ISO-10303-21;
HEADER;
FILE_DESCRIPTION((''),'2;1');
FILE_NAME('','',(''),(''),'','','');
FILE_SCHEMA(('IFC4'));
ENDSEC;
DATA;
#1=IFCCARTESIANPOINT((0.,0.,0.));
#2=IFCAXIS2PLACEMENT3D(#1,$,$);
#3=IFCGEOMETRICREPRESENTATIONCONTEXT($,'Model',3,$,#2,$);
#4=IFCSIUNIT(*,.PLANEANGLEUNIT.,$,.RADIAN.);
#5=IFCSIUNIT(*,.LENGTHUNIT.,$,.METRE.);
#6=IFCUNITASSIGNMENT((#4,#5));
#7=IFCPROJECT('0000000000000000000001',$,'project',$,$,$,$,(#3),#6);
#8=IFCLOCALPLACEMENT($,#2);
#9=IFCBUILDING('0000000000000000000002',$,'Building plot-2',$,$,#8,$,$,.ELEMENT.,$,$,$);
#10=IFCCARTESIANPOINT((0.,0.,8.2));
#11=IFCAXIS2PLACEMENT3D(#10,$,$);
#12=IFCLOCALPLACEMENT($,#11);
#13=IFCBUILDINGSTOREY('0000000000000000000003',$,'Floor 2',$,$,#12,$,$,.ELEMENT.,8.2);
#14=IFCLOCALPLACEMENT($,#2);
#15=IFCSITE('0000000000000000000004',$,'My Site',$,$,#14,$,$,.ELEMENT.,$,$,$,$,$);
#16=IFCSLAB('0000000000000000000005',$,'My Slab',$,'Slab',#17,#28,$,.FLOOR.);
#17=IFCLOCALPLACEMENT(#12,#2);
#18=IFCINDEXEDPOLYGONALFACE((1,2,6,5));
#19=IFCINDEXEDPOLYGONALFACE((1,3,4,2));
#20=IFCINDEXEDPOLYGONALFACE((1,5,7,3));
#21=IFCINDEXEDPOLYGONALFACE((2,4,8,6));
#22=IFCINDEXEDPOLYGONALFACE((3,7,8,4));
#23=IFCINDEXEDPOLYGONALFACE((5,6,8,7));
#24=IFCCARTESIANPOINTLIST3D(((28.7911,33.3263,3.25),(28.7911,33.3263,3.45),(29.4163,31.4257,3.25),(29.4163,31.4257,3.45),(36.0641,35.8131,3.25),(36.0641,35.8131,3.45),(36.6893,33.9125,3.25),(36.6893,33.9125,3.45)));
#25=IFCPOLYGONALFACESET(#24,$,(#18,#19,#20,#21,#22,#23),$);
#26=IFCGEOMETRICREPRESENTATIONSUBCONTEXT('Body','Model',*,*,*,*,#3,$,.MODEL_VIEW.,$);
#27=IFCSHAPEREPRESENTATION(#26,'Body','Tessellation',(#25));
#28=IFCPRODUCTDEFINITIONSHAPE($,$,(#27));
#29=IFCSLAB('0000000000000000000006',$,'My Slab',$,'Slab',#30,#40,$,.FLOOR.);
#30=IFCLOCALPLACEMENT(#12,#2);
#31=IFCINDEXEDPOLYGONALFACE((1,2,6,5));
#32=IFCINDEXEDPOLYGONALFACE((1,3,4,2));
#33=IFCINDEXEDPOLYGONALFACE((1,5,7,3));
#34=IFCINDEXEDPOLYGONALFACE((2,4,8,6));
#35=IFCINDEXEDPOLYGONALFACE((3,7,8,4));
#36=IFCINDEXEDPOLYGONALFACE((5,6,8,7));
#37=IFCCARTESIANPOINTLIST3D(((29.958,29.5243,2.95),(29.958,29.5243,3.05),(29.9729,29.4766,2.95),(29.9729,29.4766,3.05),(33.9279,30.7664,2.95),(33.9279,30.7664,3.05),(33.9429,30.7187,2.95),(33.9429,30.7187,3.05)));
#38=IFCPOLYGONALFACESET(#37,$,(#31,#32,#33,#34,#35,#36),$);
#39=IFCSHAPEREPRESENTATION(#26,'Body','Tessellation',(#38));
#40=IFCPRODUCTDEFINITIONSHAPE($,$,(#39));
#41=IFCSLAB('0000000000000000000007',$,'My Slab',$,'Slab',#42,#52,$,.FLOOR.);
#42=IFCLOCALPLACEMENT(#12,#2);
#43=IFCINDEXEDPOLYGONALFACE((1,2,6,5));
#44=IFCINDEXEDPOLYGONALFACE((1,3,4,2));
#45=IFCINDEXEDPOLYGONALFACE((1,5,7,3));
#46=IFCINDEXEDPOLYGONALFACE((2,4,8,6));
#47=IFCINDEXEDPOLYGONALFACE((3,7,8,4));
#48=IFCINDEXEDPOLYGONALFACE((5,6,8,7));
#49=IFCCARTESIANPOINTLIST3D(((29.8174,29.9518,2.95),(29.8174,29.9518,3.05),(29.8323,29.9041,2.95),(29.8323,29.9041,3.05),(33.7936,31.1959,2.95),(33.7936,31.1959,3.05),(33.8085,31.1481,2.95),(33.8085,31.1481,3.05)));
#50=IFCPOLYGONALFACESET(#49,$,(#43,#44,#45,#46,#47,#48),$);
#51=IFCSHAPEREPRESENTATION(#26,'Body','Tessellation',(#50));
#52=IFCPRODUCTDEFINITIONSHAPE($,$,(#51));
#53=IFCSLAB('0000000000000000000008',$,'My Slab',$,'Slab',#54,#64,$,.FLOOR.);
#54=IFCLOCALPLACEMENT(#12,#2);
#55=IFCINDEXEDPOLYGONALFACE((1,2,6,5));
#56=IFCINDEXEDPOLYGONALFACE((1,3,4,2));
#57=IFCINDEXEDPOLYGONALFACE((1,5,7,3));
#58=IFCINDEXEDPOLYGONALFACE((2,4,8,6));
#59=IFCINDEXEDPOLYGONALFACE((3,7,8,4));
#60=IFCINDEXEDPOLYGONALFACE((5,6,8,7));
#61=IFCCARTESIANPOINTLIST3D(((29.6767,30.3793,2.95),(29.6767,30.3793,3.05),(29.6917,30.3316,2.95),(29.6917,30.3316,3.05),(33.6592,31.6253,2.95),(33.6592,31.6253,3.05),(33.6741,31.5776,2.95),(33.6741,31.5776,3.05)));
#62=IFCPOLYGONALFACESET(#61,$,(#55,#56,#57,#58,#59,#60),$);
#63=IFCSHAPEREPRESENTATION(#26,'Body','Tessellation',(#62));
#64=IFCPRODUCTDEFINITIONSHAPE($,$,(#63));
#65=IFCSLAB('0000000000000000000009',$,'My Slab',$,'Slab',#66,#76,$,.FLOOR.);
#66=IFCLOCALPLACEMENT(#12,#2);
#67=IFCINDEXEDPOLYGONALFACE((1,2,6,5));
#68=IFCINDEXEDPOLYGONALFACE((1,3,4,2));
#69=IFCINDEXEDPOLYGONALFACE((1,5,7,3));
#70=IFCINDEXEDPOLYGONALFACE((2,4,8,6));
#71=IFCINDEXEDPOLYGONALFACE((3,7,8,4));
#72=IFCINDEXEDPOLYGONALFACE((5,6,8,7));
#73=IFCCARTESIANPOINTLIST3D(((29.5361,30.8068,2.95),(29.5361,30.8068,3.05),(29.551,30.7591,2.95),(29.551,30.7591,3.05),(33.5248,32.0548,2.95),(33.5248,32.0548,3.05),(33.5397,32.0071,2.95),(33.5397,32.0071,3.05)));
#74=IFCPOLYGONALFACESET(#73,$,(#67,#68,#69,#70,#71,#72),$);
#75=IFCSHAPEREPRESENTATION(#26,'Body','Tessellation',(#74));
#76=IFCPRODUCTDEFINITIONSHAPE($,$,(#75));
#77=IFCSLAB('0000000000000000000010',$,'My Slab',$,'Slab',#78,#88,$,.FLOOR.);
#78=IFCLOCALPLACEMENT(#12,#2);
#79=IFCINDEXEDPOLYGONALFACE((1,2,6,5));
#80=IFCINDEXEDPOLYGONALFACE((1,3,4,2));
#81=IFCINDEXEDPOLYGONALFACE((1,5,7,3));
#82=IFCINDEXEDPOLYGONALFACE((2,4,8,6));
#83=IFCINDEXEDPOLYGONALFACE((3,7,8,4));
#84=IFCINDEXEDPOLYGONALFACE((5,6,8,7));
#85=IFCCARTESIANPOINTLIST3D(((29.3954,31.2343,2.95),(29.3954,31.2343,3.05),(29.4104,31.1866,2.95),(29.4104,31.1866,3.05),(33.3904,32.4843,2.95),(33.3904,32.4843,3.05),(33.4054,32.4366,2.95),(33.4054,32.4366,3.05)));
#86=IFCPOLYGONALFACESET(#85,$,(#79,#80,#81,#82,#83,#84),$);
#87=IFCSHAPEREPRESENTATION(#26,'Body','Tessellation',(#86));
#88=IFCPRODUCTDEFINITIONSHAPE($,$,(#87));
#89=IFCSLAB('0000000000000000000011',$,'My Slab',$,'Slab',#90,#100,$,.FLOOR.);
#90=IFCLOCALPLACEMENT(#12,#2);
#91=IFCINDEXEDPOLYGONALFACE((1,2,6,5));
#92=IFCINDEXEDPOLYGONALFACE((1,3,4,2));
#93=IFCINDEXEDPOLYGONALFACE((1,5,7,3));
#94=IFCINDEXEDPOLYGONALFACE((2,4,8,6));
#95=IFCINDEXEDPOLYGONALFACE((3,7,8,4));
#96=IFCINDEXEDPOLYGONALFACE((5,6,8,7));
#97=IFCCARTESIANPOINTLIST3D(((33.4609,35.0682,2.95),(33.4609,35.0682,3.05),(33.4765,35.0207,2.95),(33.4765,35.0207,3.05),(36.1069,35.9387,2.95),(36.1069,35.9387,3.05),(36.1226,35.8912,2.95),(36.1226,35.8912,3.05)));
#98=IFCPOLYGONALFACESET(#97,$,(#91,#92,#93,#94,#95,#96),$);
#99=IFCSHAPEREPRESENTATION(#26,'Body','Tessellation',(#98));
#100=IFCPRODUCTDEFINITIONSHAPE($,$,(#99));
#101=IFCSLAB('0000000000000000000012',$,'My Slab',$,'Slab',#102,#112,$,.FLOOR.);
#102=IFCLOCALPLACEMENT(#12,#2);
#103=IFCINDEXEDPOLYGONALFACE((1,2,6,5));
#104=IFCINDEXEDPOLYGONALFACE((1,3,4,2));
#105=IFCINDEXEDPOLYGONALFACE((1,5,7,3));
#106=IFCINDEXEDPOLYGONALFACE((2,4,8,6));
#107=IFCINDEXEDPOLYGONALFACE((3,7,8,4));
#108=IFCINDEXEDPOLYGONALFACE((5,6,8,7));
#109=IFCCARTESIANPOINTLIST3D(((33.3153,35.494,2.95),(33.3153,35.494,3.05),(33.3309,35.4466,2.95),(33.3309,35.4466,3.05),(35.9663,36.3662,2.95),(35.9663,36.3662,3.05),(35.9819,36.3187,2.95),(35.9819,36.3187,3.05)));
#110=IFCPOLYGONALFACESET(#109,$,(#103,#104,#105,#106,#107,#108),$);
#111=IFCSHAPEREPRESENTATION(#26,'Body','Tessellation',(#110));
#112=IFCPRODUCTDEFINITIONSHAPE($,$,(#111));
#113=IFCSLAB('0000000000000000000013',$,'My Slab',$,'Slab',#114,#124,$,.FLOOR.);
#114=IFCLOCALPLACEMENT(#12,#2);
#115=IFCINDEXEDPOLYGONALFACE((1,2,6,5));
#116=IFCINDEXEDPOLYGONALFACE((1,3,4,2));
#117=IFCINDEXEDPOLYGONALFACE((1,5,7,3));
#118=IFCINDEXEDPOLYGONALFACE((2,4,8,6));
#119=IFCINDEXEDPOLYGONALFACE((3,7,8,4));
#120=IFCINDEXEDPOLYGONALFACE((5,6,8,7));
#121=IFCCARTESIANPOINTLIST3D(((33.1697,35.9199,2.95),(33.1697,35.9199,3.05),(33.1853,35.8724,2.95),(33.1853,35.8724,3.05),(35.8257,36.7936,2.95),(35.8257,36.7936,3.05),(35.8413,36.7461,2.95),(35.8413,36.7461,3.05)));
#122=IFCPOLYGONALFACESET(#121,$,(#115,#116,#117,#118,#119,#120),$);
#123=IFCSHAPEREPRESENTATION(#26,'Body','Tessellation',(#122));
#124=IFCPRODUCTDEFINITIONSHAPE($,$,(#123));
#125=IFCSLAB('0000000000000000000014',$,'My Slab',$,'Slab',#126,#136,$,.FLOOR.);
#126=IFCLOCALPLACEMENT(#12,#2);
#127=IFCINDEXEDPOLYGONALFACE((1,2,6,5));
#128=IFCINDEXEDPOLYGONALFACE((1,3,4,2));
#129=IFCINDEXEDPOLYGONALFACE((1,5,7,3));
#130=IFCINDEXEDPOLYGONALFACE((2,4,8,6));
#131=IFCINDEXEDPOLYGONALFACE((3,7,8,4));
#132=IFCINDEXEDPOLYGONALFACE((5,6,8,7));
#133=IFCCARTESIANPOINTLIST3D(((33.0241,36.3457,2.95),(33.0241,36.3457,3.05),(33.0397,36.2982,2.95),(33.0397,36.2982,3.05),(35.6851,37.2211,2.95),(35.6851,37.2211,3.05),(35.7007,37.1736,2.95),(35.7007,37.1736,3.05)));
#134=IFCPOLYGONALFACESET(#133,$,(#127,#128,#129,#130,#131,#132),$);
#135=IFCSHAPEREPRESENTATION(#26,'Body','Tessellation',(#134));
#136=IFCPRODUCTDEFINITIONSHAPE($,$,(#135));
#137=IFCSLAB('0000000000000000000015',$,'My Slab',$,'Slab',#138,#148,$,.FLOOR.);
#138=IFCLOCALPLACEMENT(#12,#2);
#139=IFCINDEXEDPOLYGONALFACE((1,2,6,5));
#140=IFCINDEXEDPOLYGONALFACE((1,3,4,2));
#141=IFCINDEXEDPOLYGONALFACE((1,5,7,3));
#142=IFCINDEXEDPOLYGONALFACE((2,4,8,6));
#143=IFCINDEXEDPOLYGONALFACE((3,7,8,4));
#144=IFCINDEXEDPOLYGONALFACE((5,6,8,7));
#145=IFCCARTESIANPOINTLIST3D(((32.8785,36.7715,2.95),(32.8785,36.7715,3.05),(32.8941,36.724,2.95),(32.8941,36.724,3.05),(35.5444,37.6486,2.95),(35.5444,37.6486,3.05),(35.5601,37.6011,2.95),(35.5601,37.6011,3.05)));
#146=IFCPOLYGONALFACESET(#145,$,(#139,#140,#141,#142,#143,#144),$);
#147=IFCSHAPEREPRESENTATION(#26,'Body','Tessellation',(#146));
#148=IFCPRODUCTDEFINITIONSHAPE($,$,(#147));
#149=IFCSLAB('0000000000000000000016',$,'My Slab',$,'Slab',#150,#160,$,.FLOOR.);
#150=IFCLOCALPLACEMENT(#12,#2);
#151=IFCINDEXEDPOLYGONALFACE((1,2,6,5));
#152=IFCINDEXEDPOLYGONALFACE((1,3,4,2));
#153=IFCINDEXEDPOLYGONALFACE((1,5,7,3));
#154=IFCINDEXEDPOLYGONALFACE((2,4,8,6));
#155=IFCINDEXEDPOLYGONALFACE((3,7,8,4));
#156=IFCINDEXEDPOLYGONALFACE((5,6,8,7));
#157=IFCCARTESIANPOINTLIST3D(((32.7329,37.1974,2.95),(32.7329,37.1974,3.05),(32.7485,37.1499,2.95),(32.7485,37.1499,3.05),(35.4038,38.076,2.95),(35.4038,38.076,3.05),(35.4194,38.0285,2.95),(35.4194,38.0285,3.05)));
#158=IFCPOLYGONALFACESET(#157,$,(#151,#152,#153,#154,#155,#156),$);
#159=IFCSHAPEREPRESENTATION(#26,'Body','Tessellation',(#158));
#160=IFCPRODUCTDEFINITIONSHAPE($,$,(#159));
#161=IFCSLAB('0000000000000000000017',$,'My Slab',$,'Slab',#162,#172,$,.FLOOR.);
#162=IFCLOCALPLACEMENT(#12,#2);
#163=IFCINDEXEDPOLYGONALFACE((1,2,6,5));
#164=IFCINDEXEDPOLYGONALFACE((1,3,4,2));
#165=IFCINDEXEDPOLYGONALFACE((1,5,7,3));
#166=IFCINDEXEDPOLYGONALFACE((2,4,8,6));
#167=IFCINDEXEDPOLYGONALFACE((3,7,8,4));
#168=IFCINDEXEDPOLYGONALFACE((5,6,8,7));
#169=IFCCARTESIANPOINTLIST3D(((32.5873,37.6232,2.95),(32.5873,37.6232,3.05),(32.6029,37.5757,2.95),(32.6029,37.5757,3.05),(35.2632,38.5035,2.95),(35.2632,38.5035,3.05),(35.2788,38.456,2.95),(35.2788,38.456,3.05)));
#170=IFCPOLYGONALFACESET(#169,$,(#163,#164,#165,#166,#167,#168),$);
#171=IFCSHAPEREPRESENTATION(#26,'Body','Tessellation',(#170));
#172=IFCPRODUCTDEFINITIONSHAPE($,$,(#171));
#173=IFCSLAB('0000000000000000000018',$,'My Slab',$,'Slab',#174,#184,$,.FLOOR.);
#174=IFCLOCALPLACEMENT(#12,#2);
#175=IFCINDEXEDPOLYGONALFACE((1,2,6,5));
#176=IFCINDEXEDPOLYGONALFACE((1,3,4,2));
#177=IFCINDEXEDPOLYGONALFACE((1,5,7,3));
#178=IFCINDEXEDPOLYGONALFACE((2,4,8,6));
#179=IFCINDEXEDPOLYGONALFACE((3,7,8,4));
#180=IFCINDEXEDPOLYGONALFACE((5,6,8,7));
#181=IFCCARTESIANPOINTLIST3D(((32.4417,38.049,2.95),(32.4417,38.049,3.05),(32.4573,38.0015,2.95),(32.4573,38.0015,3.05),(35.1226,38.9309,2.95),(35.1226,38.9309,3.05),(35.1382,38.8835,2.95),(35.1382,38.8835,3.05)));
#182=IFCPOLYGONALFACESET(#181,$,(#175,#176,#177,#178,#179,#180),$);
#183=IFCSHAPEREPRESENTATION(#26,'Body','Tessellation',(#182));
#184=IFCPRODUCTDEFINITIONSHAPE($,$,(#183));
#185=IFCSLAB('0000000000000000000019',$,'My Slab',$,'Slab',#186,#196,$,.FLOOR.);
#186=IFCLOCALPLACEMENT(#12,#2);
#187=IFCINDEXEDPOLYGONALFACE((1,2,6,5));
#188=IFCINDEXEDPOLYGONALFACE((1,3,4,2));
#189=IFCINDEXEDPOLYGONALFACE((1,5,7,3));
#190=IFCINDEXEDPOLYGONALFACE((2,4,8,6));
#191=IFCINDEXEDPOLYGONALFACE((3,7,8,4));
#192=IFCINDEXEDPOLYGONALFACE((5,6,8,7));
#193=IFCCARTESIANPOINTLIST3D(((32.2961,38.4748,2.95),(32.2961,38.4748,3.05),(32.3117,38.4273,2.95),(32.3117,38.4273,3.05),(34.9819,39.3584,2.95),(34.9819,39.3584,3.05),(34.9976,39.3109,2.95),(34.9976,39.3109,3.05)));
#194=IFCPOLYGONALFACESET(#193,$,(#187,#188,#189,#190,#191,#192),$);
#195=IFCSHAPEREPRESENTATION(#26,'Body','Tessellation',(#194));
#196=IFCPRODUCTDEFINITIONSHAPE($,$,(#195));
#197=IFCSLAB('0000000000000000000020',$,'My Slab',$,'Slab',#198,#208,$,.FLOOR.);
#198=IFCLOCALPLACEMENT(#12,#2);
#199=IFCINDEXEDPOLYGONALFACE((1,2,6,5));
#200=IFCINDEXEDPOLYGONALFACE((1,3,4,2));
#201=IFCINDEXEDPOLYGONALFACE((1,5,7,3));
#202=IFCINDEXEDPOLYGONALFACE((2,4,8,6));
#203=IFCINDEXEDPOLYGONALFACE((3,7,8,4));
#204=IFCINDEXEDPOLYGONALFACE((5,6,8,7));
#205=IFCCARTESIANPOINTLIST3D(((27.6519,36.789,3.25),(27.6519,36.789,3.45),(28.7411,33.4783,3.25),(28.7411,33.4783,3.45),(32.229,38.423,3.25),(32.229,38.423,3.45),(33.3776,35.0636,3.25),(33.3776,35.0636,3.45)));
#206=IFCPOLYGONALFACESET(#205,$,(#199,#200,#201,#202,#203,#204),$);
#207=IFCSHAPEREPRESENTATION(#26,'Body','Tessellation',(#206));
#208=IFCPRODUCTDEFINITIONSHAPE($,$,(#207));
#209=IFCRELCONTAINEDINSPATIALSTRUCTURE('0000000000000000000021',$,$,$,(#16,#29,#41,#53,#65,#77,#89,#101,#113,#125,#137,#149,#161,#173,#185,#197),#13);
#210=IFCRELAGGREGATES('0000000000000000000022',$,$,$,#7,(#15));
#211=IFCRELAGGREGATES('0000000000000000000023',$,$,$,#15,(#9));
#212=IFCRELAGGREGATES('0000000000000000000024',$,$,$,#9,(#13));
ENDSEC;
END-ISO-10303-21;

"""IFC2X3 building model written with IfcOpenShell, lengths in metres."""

from ifc_helpers import new_model, si_unit, frame, origin, place, context, subcontext, project, spatial, polyline, outline, extrude, element, save


model = new_model("IFC2X3")

# Units and contexts
model_context = context("Model", 3, world=origin())
body_context = subcontext(model_context, "Body", "Model", "MODEL_VIEW")
ifc_project = project(units=[si_unit("PLANEANGLEUNIT", "RADIAN"), si_unit("LENGTHUNIT", "METRE")], contexts=[model_context])

# Site, building, storey
site_placement = place(None, origin())
site = spatial("IfcSite", under=ifc_project, at=site_placement, Name="My Site", CompositionType="ELEMENT")
building_placement = place(None, origin())
building = spatial("IfcBuilding", under=site, at=building_placement, Name="Building plot-2", CompositionType="ELEMENT")
storey_placement = place(None, frame((0.0, 0.0, 8.2)))
storey = spatial("IfcBuildingStorey", under=building, at=storey_placement, Name="Floor 2", CompositionType="ELEMENT", Elevation=8.2)

# Slabs
slab_1_placement = place(storey_placement, frame((0.0, 0.0, 3.25)))
element("IfcSlab", 1, at=slab_1_placement, inside=storey, Name="My Slab", ObjectType="Slab", PredefinedType="FLOOR", context=body_context, shape_type="SweptSolid", body=[
    extrude(outline(polyline([(28.7911, 33.3263), (29.4163, 31.4257), (36.6893, 33.9125), (36.0641, 35.8131), (28.7911, 33.3263)])), origin(), (0.0, 0.0, 1.0), 0.2),
])
slab_2_placement = place(storey_placement, frame((0.0, 0.0, 2.95)))
element("IfcSlab", 2, at=slab_2_placement, inside=storey, Name="My Slab", ObjectType="Slab", PredefinedType="FLOOR", context=body_context, shape_type="SweptSolid", body=[
    extrude(outline(polyline([(33.9429, 30.7187), (33.9279, 30.7664), (29.958, 29.5243), (29.9729, 29.4766), (33.9429, 30.7187)])), origin(), (0.0, 0.0, 1.0), 0.1),
])
slab_3_placement = place(storey_placement, frame((0.0, 0.0, 2.95)))
element("IfcSlab", 3, at=slab_3_placement, inside=storey, Name="My Slab", ObjectType="Slab", PredefinedType="FLOOR", context=body_context, shape_type="SweptSolid", body=[
    extrude(outline(polyline([(33.8085, 31.1481), (33.7936, 31.1959), (29.8174, 29.9518), (29.8323, 29.9041), (33.8085, 31.1481)])), origin(), (0.0, 0.0, 1.0), 0.1),
])
slab_4_placement = place(storey_placement, frame((0.0, 0.0, 2.95)))
element("IfcSlab", 4, at=slab_4_placement, inside=storey, Name="My Slab", ObjectType="Slab", PredefinedType="FLOOR", context=body_context, shape_type="SweptSolid", body=[
    extrude(outline(polyline([(33.6741, 31.5776), (33.6592, 31.6253), (29.6767, 30.3793), (29.6917, 30.3316), (33.6741, 31.5776)])), origin(), (0.0, 0.0, 1.0), 0.1),
])
slab_5_placement = place(storey_placement, frame((0.0, 0.0, 2.95)))
element("IfcSlab", 5, at=slab_5_placement, inside=storey, Name="My Slab", ObjectType="Slab", PredefinedType="FLOOR", context=body_context, shape_type="SweptSolid", body=[
    extrude(outline(polyline([(33.5397, 32.0071), (33.5248, 32.0548), (29.5361, 30.8068), (29.551, 30.7591), (33.5397, 32.0071)])), origin(), (0.0, 0.0, 1.0), 0.1),
])
slab_6_placement = place(storey_placement, frame((0.0, 0.0, 2.95)))
element("IfcSlab", 6, at=slab_6_placement, inside=storey, Name="My Slab", ObjectType="Slab", PredefinedType="FLOOR", context=body_context, shape_type="SweptSolid", body=[
    extrude(outline(polyline([(33.4054, 32.4366), (33.3904, 32.4843), (29.3954, 31.2343), (29.4104, 31.1866), (33.4054, 32.4366)])), origin(), (0.0, 0.0, 1.0), 0.1),
])
slab_7_placement = place(storey_placement, frame((0.0, 0.0, 2.95)))
element("IfcSlab", 7, at=slab_7_placement, inside=storey, Name="My Slab", ObjectType="Slab", PredefinedType="FLOOR", context=body_context, shape_type="SweptSolid", body=[
    extrude(outline(polyline([(36.1226, 35.8912), (36.1069, 35.9387), (33.4609, 35.0682), (33.4765, 35.0207), (36.1226, 35.8912)])), origin(), (0.0, 0.0, 1.0), 0.1),
])
slab_8_placement = place(storey_placement, frame((0.0, 0.0, 2.95)))
element("IfcSlab", 8, at=slab_8_placement, inside=storey, Name="My Slab", ObjectType="Slab", PredefinedType="FLOOR", context=body_context, shape_type="SweptSolid", body=[
    extrude(outline(polyline([(35.9819, 36.3187), (35.9663, 36.3662), (33.3153, 35.494), (33.3309, 35.4466), (35.9819, 36.3187)])), origin(), (0.0, 0.0, 1.0), 0.1),
])
slab_9_placement = place(storey_placement, frame((0.0, 0.0, 2.95)))
element("IfcSlab", 9, at=slab_9_placement, inside=storey, Name="My Slab", ObjectType="Slab", PredefinedType="FLOOR", context=body_context, shape_type="SweptSolid", body=[
    extrude(outline(polyline([(35.8413, 36.7461), (35.8257, 36.7936), (33.1697, 35.9199), (33.1853, 35.8724), (35.8413, 36.7461)])), origin(), (0.0, 0.0, 1.0), 0.1),
])
slab_10_placement = place(storey_placement, frame((0.0, 0.0, 2.95)))
element("IfcSlab", 10, at=slab_10_placement, inside=storey, Name="My Slab", ObjectType="Slab", PredefinedType="FLOOR", context=body_context, shape_type="SweptSolid", body=[
    extrude(outline(polyline([(35.7007, 37.1736), (35.6851, 37.2211), (33.0241, 36.3457), (33.0397, 36.2982), (35.7007, 37.1736)])), origin(), (0.0, 0.0, 1.0), 0.1),
])
slab_11_placement = place(storey_placement, frame((0.0, 0.0, 2.95)))
element("IfcSlab", 11, at=slab_11_placement, inside=storey, Name="My Slab", ObjectType="Slab", PredefinedType="FLOOR", context=body_context, shape_type="SweptSolid", body=[
    extrude(outline(polyline([(35.5601, 37.6011), (35.5444, 37.6486), (32.8785, 36.7715), (32.8941, 36.724), (35.5601, 37.6011)])), origin(), (0.0, 0.0, 1.0), 0.1),
])
slab_12_placement = place(storey_placement, frame((0.0, 0.0, 2.95)))
element("IfcSlab", 12, at=slab_12_placement, inside=storey, Name="My Slab", ObjectType="Slab", PredefinedType="FLOOR", context=body_context, shape_type="SweptSolid", body=[
    extrude(outline(polyline([(35.4194, 38.0285), (35.4038, 38.076), (32.7329, 37.1974), (32.7485, 37.1499), (35.4194, 38.0285)])), origin(), (0.0, 0.0, 1.0), 0.1),
])
slab_13_placement = place(storey_placement, frame((0.0, 0.0, 2.95)))
element("IfcSlab", 13, at=slab_13_placement, inside=storey, Name="My Slab", ObjectType="Slab", PredefinedType="FLOOR", context=body_context, shape_type="SweptSolid", body=[
    extrude(outline(polyline([(35.2788, 38.456), (35.2632, 38.5035), (32.5873, 37.6232), (32.6029, 37.5757), (35.2788, 38.456)])), origin(), (0.0, 0.0, 1.0), 0.1),
])
slab_14_placement = place(storey_placement, frame((0.0, 0.0, 2.95)))
element("IfcSlab", 14, at=slab_14_placement, inside=storey, Name="My Slab", ObjectType="Slab", PredefinedType="FLOOR", context=body_context, shape_type="SweptSolid", body=[
    extrude(outline(polyline([(35.1382, 38.8835), (35.1226, 38.9309), (32.4417, 38.049), (32.4573, 38.0015), (35.1382, 38.8835)])), origin(), (0.0, 0.0, 1.0), 0.1),
])
slab_15_placement = place(storey_placement, frame((0.0, 0.0, 2.95)))
element("IfcSlab", 15, at=slab_15_placement, inside=storey, Name="My Slab", ObjectType="Slab", PredefinedType="FLOOR", context=body_context, shape_type="SweptSolid", body=[
    extrude(outline(polyline([(34.9976, 39.3109), (34.9819, 39.3584), (32.2961, 38.4748), (32.3117, 38.4273), (34.9976, 39.3109)])), origin(), (0.0, 0.0, 1.0), 0.1),
])
slab_16_placement = place(storey_placement, frame((0.0, 0.0, 3.25)))
element("IfcSlab", 16, at=slab_16_placement, inside=storey, Name="My Slab", ObjectType="Slab", PredefinedType="FLOOR", context=body_context, shape_type="SweptSolid", body=[
    extrude(outline(polyline([(28.7411, 33.4783), (33.3776, 35.0636), (32.229, 38.423), (27.6519, 36.789), (28.7411, 33.4783)])), origin(), (0.0, 0.0, 1.0), 0.2),
])

save(model, "model.ifc")
